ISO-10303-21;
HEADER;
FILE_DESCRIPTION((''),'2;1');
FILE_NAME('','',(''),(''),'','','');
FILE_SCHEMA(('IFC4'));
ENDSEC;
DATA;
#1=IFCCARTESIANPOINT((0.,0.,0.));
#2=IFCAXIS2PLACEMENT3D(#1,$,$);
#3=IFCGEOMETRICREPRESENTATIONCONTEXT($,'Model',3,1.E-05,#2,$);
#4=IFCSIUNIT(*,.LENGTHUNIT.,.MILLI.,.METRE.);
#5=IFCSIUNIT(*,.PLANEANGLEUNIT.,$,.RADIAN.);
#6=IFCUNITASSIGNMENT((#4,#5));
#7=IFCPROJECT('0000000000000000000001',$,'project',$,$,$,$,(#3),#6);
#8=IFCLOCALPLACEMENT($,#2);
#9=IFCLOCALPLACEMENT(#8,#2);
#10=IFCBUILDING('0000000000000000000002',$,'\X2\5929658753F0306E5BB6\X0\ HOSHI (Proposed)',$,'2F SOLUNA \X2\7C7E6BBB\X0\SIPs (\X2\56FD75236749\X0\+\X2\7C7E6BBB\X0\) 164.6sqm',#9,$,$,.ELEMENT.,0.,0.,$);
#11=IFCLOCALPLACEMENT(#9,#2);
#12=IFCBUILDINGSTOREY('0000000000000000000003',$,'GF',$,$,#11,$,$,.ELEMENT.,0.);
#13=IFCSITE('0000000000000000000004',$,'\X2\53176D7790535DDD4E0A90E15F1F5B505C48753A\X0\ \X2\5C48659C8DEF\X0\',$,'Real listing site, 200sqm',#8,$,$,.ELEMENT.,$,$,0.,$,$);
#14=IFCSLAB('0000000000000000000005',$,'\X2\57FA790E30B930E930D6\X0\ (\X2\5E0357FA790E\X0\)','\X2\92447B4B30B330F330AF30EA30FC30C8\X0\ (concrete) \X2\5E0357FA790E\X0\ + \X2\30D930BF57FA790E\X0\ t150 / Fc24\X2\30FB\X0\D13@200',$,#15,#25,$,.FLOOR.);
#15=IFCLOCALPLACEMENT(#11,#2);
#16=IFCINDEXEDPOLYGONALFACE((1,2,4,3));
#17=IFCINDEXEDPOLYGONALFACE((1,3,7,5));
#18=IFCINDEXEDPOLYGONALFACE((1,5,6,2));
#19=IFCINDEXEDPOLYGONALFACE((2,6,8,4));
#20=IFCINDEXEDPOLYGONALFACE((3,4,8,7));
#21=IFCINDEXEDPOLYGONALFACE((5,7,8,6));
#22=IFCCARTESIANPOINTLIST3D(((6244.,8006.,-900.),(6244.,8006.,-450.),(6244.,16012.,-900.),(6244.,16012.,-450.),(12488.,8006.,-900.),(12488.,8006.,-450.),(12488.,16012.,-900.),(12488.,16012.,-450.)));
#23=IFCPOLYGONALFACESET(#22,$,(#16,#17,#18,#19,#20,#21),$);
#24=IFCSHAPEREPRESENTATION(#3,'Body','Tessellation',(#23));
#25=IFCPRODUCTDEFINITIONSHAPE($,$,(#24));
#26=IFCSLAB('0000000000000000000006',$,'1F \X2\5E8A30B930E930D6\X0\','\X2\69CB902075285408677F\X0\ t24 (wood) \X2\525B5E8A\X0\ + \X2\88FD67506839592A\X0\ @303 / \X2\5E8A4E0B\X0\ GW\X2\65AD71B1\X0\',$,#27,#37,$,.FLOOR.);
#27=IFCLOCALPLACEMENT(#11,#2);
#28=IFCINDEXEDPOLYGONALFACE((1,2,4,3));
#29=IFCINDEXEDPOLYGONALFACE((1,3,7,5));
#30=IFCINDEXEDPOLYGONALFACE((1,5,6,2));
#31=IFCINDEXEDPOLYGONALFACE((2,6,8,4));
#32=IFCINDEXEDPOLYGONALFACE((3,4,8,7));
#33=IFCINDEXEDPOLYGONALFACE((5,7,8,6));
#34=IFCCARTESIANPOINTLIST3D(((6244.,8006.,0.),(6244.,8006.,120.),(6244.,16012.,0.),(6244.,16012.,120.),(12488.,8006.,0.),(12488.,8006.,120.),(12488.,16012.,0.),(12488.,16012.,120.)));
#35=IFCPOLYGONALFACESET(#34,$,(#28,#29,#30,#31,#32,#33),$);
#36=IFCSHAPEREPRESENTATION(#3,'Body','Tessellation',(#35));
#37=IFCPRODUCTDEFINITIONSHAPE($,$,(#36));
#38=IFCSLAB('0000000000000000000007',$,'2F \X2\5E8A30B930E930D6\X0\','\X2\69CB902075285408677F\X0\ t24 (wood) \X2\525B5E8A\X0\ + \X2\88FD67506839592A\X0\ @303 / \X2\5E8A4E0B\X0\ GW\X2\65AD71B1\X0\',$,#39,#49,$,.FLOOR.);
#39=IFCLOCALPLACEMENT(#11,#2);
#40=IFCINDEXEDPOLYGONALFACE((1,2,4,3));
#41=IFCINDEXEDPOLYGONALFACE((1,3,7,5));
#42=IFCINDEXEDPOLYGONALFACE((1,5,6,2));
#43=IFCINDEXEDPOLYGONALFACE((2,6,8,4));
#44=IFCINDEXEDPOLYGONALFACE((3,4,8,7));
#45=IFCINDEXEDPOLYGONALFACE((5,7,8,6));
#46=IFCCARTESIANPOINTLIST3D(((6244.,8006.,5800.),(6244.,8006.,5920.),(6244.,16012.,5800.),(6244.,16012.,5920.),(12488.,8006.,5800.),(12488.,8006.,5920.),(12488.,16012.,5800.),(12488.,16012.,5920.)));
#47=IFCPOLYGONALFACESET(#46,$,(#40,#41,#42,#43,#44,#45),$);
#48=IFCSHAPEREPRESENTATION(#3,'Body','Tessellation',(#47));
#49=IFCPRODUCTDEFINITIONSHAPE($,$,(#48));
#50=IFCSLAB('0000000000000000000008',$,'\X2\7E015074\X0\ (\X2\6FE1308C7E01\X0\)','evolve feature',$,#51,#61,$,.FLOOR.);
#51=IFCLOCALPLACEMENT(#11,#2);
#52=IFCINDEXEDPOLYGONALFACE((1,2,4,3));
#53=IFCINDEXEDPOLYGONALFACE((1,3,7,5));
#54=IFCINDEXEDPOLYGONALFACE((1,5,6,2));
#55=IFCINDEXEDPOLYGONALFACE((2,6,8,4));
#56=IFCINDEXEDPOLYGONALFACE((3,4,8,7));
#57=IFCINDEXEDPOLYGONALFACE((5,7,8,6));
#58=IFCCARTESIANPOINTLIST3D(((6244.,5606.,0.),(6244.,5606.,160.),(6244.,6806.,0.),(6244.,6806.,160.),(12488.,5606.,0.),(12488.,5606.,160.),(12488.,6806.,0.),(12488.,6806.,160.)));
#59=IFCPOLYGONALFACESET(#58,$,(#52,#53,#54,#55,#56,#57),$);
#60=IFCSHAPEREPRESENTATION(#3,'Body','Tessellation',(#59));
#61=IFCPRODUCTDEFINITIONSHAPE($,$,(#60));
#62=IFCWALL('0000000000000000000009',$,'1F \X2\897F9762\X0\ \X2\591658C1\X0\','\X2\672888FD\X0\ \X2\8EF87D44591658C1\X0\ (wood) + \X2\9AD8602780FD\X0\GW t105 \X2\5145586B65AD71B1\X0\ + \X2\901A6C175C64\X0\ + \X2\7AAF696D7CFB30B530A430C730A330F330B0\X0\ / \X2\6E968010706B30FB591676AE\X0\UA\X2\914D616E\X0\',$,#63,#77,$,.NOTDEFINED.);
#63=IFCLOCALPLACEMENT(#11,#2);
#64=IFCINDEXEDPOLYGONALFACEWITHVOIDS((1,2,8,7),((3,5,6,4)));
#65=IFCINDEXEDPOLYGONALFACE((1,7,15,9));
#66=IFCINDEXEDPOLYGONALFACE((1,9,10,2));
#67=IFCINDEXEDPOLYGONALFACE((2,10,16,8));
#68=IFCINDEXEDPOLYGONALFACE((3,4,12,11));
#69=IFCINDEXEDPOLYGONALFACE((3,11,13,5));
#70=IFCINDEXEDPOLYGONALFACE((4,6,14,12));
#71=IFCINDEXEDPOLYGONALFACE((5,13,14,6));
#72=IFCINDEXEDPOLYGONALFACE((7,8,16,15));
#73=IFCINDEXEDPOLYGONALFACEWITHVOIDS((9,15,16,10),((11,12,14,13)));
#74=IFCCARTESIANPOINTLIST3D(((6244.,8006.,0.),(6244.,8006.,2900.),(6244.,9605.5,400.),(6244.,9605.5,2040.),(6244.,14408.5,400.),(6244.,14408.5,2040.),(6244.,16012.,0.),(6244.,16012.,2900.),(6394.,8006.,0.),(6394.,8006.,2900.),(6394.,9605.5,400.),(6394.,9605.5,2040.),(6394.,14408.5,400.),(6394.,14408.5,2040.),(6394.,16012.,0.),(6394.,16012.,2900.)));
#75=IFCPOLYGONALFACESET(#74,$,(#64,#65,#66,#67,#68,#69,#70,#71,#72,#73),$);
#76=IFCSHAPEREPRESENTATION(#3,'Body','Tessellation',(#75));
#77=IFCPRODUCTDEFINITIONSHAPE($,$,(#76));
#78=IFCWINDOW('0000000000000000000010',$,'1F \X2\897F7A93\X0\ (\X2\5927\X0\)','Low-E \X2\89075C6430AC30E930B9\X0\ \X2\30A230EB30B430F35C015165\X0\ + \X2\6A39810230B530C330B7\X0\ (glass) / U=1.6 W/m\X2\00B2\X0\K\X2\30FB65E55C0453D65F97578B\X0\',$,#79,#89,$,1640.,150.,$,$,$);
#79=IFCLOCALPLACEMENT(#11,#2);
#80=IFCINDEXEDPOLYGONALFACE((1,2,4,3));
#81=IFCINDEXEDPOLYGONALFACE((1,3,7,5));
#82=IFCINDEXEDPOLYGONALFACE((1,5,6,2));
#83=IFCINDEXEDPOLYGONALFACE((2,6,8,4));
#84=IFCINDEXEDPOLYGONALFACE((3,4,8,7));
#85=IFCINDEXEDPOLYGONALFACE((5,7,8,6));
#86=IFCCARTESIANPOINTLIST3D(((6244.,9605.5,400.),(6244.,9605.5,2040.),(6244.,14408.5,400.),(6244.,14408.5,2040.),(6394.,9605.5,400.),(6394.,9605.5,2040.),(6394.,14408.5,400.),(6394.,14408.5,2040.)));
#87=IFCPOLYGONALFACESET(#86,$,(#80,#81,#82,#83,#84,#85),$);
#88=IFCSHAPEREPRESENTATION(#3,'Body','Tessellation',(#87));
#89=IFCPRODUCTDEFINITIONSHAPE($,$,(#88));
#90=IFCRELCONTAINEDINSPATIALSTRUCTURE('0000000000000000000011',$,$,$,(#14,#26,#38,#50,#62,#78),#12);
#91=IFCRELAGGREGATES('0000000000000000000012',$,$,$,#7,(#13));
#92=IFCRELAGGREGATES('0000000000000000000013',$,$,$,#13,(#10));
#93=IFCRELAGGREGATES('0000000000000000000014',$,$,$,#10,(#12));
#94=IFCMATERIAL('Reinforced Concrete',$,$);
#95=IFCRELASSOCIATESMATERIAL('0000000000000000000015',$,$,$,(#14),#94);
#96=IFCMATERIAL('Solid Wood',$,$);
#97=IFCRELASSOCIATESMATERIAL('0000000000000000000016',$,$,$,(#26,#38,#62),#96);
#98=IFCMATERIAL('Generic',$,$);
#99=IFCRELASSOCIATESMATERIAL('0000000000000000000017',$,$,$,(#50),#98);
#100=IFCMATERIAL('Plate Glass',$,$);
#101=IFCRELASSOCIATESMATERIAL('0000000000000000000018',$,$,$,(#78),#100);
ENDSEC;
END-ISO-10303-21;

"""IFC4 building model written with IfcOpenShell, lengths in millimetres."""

from ifc_helpers import new_model, si_unit, frame, frame_2d, origin, place, context, project, spatial, rectangle, extrude, material, element, fill, save


model = new_model("IFC4")

# Units and contexts
model_context = context("Model", 3, precision=1e-05, world=origin())
ifc_project = project(units=[si_unit("LENGTHUNIT", "METRE", prefix="MILLI"), si_unit("PLANEANGLEUNIT", "RADIAN")], contexts=[model_context])

# Site, building, storey
site_placement = place(None, origin())
site = spatial("IfcSite", under=ifc_project, at=site_placement, Name="北海道川上郡弟子屈町 屈斜路", ObjectType="Real listing site, 200sqm", CompositionType="ELEMENT", RefElevation=0.0)
building_placement = place(site_placement, origin())
building = spatial("IfcBuilding", under=site, at=building_placement, Name="天文台の家 HOSHI (Proposed)", ObjectType="2F SOLUNA 籾殻SIPs (国産杉+籾殻) 164.6sqm", CompositionType="ELEMENT", ElevationOfRefHeight=0.0, ElevationOfTerrain=0.0)
storey_placement = place(building_placement, origin())
storey = spatial("IfcBuildingStorey", under=building, at=storey_placement, Name="GF", CompositionType="ELEMENT", Elevation=0.0)

# Slabs
ifc_material_1 = material(Name="Reinforced Concrete")
slab_1_placement = place(storey_placement, frame((3122.0, 4003.0, -450.0)))
element("IfcSlab", 1, at=slab_1_placement, inside=storey, material=ifc_material_1, Name="基礎スラブ (布基礎)", Description="鉄筋コンクリート (concrete) 布基礎 + ベタ基礎 t150 / Fc24・D13@200", PredefinedType="FLOOR", context=model_context, shape_type="SweptSolid", body=[
    extrude(rectangle(XDim=6244.0, YDim=8006.0, at=frame_2d((3122.0, 4003.0))), frame((3122.0, 4003.0, -450.0)), (0.0, 0.0, 1.0), 450.0),
])
ifc_material_2 = material(Name="Solid Wood")
slab_2_placement = place(storey_placement, frame((3122.0, 4003.0, 0.0)))
element("IfcSlab", 2, at=slab_2_placement, inside=storey, material=ifc_material_2, Name="1F 床スラブ", Description="構造用合板 t24 (wood) 剛床 + 製材根太 @303 / 床下 GW断熱", PredefinedType="FLOOR", context=model_context, shape_type="SweptSolid", body=[
    extrude(rectangle(XDim=6244.0, YDim=8006.0, at=frame_2d((3122.0, 4003.0))), frame((3122.0, 4003.0, 0.0)), (0.0, 0.0, 1.0), 120.0),
])
slab_3_placement = place(storey_placement, frame((3122.0, 4003.0, 2900.0)))
element("IfcSlab", 3, at=slab_3_placement, inside=storey, material=ifc_material_2, Name="2F 床スラブ", Description="構造用合板 t24 (wood) 剛床 + 製材根太 @303 / 床下 GW断熱", PredefinedType="FLOOR", context=model_context, shape_type="SweptSolid", body=[
    extrude(rectangle(XDim=6244.0, YDim=8006.0, at=frame_2d((3122.0, 4003.0))), frame((3122.0, 4003.0, 2900.0)), (0.0, 0.0, 1.0), 120.0),
])
ifc_material_3 = material(Name="Generic")
slab_4_placement = place(storey_placement, frame((3122.0, 2803.0, 0.0)))
element("IfcSlab", 4, at=slab_4_placement, inside=storey, material=ifc_material_3, Name="縁側 (濡れ縁)", Description="evolve feature", PredefinedType="FLOOR", context=model_context, shape_type="SweptSolid", body=[
    extrude(rectangle(XDim=6244.0, YDim=1200.0, at=frame_2d((3122.0, 600.0))), frame((3122.0, 2803.0, 0.0)), (0.0, 0.0, 1.0), 160.0),
])

# Shared definitions
ifc_material_4 = material(Name="Plate Glass")

# Wall, opening, window
wall_1_placement = place(storey_placement, frame((3122.0, 4003.0, 0.0)))
wall_1 = element("IfcWall", 5, at=wall_1_placement, inside=storey, material=ifc_material_2, Name="1F 西面 外壁", Description="木製 軸組外壁 (wood) + 高性能GW t105 充填断熱 + 通気層 + 窯業系サイディング / 準耐火・外皮UA配慮", PredefinedType="NOTDEFINED", context=model_context, shape_type="SweptSolid", body=[
    extrude(rectangle(XDim=150.0, YDim=8006.0, at=frame_2d((75.0, 4003.0))), frame((3122.0, 4003.0, 0.0)), (0.0, 0.0, 1.0), 2900.0),
])
opening_1_placement = place(storey_placement, frame((3122.0, 4803.0, 200.0)))
opening_1 = element("IfcOpeningElement", 6, at=opening_1_placement, cuts=wall_1, PredefinedType="NOTDEFINED", context=model_context, shape_type="SweptSolid", body=[
    extrude(rectangle(XDim=150.0, YDim=4803.0, at=frame_2d((75.0, 2401.0))), frame((3122.0, 4803.0, 200.0)), (0.0, 0.0, 1.0), 1640.0),
])
window_1_placement = place(storey_placement, frame((3122.0, 4803.0, 200.0)))
window_1 = element("IfcWindow", 7, at=window_1_placement, inside=storey, material=ifc_material_4, Name="1F 西窓 (大)", Description="Low-E 複層ガラス アルゴン封入 + 樹脂サッシ (glass) / U=1.6 W/m²K・日射取得型", OverallHeight=1640.0, OverallWidth=150.0, context=model_context, shape_type="SweptSolid", body=[
    extrude(rectangle(XDim=150.0, YDim=4803.0, at=frame_2d((75.0, 2401.0))), frame((3122.0, 4803.0, 200.0)), (0.0, 0.0, 1.0), 1640.0),
])
fill(opening_1, window_1)

save(model, "model.ifc")
